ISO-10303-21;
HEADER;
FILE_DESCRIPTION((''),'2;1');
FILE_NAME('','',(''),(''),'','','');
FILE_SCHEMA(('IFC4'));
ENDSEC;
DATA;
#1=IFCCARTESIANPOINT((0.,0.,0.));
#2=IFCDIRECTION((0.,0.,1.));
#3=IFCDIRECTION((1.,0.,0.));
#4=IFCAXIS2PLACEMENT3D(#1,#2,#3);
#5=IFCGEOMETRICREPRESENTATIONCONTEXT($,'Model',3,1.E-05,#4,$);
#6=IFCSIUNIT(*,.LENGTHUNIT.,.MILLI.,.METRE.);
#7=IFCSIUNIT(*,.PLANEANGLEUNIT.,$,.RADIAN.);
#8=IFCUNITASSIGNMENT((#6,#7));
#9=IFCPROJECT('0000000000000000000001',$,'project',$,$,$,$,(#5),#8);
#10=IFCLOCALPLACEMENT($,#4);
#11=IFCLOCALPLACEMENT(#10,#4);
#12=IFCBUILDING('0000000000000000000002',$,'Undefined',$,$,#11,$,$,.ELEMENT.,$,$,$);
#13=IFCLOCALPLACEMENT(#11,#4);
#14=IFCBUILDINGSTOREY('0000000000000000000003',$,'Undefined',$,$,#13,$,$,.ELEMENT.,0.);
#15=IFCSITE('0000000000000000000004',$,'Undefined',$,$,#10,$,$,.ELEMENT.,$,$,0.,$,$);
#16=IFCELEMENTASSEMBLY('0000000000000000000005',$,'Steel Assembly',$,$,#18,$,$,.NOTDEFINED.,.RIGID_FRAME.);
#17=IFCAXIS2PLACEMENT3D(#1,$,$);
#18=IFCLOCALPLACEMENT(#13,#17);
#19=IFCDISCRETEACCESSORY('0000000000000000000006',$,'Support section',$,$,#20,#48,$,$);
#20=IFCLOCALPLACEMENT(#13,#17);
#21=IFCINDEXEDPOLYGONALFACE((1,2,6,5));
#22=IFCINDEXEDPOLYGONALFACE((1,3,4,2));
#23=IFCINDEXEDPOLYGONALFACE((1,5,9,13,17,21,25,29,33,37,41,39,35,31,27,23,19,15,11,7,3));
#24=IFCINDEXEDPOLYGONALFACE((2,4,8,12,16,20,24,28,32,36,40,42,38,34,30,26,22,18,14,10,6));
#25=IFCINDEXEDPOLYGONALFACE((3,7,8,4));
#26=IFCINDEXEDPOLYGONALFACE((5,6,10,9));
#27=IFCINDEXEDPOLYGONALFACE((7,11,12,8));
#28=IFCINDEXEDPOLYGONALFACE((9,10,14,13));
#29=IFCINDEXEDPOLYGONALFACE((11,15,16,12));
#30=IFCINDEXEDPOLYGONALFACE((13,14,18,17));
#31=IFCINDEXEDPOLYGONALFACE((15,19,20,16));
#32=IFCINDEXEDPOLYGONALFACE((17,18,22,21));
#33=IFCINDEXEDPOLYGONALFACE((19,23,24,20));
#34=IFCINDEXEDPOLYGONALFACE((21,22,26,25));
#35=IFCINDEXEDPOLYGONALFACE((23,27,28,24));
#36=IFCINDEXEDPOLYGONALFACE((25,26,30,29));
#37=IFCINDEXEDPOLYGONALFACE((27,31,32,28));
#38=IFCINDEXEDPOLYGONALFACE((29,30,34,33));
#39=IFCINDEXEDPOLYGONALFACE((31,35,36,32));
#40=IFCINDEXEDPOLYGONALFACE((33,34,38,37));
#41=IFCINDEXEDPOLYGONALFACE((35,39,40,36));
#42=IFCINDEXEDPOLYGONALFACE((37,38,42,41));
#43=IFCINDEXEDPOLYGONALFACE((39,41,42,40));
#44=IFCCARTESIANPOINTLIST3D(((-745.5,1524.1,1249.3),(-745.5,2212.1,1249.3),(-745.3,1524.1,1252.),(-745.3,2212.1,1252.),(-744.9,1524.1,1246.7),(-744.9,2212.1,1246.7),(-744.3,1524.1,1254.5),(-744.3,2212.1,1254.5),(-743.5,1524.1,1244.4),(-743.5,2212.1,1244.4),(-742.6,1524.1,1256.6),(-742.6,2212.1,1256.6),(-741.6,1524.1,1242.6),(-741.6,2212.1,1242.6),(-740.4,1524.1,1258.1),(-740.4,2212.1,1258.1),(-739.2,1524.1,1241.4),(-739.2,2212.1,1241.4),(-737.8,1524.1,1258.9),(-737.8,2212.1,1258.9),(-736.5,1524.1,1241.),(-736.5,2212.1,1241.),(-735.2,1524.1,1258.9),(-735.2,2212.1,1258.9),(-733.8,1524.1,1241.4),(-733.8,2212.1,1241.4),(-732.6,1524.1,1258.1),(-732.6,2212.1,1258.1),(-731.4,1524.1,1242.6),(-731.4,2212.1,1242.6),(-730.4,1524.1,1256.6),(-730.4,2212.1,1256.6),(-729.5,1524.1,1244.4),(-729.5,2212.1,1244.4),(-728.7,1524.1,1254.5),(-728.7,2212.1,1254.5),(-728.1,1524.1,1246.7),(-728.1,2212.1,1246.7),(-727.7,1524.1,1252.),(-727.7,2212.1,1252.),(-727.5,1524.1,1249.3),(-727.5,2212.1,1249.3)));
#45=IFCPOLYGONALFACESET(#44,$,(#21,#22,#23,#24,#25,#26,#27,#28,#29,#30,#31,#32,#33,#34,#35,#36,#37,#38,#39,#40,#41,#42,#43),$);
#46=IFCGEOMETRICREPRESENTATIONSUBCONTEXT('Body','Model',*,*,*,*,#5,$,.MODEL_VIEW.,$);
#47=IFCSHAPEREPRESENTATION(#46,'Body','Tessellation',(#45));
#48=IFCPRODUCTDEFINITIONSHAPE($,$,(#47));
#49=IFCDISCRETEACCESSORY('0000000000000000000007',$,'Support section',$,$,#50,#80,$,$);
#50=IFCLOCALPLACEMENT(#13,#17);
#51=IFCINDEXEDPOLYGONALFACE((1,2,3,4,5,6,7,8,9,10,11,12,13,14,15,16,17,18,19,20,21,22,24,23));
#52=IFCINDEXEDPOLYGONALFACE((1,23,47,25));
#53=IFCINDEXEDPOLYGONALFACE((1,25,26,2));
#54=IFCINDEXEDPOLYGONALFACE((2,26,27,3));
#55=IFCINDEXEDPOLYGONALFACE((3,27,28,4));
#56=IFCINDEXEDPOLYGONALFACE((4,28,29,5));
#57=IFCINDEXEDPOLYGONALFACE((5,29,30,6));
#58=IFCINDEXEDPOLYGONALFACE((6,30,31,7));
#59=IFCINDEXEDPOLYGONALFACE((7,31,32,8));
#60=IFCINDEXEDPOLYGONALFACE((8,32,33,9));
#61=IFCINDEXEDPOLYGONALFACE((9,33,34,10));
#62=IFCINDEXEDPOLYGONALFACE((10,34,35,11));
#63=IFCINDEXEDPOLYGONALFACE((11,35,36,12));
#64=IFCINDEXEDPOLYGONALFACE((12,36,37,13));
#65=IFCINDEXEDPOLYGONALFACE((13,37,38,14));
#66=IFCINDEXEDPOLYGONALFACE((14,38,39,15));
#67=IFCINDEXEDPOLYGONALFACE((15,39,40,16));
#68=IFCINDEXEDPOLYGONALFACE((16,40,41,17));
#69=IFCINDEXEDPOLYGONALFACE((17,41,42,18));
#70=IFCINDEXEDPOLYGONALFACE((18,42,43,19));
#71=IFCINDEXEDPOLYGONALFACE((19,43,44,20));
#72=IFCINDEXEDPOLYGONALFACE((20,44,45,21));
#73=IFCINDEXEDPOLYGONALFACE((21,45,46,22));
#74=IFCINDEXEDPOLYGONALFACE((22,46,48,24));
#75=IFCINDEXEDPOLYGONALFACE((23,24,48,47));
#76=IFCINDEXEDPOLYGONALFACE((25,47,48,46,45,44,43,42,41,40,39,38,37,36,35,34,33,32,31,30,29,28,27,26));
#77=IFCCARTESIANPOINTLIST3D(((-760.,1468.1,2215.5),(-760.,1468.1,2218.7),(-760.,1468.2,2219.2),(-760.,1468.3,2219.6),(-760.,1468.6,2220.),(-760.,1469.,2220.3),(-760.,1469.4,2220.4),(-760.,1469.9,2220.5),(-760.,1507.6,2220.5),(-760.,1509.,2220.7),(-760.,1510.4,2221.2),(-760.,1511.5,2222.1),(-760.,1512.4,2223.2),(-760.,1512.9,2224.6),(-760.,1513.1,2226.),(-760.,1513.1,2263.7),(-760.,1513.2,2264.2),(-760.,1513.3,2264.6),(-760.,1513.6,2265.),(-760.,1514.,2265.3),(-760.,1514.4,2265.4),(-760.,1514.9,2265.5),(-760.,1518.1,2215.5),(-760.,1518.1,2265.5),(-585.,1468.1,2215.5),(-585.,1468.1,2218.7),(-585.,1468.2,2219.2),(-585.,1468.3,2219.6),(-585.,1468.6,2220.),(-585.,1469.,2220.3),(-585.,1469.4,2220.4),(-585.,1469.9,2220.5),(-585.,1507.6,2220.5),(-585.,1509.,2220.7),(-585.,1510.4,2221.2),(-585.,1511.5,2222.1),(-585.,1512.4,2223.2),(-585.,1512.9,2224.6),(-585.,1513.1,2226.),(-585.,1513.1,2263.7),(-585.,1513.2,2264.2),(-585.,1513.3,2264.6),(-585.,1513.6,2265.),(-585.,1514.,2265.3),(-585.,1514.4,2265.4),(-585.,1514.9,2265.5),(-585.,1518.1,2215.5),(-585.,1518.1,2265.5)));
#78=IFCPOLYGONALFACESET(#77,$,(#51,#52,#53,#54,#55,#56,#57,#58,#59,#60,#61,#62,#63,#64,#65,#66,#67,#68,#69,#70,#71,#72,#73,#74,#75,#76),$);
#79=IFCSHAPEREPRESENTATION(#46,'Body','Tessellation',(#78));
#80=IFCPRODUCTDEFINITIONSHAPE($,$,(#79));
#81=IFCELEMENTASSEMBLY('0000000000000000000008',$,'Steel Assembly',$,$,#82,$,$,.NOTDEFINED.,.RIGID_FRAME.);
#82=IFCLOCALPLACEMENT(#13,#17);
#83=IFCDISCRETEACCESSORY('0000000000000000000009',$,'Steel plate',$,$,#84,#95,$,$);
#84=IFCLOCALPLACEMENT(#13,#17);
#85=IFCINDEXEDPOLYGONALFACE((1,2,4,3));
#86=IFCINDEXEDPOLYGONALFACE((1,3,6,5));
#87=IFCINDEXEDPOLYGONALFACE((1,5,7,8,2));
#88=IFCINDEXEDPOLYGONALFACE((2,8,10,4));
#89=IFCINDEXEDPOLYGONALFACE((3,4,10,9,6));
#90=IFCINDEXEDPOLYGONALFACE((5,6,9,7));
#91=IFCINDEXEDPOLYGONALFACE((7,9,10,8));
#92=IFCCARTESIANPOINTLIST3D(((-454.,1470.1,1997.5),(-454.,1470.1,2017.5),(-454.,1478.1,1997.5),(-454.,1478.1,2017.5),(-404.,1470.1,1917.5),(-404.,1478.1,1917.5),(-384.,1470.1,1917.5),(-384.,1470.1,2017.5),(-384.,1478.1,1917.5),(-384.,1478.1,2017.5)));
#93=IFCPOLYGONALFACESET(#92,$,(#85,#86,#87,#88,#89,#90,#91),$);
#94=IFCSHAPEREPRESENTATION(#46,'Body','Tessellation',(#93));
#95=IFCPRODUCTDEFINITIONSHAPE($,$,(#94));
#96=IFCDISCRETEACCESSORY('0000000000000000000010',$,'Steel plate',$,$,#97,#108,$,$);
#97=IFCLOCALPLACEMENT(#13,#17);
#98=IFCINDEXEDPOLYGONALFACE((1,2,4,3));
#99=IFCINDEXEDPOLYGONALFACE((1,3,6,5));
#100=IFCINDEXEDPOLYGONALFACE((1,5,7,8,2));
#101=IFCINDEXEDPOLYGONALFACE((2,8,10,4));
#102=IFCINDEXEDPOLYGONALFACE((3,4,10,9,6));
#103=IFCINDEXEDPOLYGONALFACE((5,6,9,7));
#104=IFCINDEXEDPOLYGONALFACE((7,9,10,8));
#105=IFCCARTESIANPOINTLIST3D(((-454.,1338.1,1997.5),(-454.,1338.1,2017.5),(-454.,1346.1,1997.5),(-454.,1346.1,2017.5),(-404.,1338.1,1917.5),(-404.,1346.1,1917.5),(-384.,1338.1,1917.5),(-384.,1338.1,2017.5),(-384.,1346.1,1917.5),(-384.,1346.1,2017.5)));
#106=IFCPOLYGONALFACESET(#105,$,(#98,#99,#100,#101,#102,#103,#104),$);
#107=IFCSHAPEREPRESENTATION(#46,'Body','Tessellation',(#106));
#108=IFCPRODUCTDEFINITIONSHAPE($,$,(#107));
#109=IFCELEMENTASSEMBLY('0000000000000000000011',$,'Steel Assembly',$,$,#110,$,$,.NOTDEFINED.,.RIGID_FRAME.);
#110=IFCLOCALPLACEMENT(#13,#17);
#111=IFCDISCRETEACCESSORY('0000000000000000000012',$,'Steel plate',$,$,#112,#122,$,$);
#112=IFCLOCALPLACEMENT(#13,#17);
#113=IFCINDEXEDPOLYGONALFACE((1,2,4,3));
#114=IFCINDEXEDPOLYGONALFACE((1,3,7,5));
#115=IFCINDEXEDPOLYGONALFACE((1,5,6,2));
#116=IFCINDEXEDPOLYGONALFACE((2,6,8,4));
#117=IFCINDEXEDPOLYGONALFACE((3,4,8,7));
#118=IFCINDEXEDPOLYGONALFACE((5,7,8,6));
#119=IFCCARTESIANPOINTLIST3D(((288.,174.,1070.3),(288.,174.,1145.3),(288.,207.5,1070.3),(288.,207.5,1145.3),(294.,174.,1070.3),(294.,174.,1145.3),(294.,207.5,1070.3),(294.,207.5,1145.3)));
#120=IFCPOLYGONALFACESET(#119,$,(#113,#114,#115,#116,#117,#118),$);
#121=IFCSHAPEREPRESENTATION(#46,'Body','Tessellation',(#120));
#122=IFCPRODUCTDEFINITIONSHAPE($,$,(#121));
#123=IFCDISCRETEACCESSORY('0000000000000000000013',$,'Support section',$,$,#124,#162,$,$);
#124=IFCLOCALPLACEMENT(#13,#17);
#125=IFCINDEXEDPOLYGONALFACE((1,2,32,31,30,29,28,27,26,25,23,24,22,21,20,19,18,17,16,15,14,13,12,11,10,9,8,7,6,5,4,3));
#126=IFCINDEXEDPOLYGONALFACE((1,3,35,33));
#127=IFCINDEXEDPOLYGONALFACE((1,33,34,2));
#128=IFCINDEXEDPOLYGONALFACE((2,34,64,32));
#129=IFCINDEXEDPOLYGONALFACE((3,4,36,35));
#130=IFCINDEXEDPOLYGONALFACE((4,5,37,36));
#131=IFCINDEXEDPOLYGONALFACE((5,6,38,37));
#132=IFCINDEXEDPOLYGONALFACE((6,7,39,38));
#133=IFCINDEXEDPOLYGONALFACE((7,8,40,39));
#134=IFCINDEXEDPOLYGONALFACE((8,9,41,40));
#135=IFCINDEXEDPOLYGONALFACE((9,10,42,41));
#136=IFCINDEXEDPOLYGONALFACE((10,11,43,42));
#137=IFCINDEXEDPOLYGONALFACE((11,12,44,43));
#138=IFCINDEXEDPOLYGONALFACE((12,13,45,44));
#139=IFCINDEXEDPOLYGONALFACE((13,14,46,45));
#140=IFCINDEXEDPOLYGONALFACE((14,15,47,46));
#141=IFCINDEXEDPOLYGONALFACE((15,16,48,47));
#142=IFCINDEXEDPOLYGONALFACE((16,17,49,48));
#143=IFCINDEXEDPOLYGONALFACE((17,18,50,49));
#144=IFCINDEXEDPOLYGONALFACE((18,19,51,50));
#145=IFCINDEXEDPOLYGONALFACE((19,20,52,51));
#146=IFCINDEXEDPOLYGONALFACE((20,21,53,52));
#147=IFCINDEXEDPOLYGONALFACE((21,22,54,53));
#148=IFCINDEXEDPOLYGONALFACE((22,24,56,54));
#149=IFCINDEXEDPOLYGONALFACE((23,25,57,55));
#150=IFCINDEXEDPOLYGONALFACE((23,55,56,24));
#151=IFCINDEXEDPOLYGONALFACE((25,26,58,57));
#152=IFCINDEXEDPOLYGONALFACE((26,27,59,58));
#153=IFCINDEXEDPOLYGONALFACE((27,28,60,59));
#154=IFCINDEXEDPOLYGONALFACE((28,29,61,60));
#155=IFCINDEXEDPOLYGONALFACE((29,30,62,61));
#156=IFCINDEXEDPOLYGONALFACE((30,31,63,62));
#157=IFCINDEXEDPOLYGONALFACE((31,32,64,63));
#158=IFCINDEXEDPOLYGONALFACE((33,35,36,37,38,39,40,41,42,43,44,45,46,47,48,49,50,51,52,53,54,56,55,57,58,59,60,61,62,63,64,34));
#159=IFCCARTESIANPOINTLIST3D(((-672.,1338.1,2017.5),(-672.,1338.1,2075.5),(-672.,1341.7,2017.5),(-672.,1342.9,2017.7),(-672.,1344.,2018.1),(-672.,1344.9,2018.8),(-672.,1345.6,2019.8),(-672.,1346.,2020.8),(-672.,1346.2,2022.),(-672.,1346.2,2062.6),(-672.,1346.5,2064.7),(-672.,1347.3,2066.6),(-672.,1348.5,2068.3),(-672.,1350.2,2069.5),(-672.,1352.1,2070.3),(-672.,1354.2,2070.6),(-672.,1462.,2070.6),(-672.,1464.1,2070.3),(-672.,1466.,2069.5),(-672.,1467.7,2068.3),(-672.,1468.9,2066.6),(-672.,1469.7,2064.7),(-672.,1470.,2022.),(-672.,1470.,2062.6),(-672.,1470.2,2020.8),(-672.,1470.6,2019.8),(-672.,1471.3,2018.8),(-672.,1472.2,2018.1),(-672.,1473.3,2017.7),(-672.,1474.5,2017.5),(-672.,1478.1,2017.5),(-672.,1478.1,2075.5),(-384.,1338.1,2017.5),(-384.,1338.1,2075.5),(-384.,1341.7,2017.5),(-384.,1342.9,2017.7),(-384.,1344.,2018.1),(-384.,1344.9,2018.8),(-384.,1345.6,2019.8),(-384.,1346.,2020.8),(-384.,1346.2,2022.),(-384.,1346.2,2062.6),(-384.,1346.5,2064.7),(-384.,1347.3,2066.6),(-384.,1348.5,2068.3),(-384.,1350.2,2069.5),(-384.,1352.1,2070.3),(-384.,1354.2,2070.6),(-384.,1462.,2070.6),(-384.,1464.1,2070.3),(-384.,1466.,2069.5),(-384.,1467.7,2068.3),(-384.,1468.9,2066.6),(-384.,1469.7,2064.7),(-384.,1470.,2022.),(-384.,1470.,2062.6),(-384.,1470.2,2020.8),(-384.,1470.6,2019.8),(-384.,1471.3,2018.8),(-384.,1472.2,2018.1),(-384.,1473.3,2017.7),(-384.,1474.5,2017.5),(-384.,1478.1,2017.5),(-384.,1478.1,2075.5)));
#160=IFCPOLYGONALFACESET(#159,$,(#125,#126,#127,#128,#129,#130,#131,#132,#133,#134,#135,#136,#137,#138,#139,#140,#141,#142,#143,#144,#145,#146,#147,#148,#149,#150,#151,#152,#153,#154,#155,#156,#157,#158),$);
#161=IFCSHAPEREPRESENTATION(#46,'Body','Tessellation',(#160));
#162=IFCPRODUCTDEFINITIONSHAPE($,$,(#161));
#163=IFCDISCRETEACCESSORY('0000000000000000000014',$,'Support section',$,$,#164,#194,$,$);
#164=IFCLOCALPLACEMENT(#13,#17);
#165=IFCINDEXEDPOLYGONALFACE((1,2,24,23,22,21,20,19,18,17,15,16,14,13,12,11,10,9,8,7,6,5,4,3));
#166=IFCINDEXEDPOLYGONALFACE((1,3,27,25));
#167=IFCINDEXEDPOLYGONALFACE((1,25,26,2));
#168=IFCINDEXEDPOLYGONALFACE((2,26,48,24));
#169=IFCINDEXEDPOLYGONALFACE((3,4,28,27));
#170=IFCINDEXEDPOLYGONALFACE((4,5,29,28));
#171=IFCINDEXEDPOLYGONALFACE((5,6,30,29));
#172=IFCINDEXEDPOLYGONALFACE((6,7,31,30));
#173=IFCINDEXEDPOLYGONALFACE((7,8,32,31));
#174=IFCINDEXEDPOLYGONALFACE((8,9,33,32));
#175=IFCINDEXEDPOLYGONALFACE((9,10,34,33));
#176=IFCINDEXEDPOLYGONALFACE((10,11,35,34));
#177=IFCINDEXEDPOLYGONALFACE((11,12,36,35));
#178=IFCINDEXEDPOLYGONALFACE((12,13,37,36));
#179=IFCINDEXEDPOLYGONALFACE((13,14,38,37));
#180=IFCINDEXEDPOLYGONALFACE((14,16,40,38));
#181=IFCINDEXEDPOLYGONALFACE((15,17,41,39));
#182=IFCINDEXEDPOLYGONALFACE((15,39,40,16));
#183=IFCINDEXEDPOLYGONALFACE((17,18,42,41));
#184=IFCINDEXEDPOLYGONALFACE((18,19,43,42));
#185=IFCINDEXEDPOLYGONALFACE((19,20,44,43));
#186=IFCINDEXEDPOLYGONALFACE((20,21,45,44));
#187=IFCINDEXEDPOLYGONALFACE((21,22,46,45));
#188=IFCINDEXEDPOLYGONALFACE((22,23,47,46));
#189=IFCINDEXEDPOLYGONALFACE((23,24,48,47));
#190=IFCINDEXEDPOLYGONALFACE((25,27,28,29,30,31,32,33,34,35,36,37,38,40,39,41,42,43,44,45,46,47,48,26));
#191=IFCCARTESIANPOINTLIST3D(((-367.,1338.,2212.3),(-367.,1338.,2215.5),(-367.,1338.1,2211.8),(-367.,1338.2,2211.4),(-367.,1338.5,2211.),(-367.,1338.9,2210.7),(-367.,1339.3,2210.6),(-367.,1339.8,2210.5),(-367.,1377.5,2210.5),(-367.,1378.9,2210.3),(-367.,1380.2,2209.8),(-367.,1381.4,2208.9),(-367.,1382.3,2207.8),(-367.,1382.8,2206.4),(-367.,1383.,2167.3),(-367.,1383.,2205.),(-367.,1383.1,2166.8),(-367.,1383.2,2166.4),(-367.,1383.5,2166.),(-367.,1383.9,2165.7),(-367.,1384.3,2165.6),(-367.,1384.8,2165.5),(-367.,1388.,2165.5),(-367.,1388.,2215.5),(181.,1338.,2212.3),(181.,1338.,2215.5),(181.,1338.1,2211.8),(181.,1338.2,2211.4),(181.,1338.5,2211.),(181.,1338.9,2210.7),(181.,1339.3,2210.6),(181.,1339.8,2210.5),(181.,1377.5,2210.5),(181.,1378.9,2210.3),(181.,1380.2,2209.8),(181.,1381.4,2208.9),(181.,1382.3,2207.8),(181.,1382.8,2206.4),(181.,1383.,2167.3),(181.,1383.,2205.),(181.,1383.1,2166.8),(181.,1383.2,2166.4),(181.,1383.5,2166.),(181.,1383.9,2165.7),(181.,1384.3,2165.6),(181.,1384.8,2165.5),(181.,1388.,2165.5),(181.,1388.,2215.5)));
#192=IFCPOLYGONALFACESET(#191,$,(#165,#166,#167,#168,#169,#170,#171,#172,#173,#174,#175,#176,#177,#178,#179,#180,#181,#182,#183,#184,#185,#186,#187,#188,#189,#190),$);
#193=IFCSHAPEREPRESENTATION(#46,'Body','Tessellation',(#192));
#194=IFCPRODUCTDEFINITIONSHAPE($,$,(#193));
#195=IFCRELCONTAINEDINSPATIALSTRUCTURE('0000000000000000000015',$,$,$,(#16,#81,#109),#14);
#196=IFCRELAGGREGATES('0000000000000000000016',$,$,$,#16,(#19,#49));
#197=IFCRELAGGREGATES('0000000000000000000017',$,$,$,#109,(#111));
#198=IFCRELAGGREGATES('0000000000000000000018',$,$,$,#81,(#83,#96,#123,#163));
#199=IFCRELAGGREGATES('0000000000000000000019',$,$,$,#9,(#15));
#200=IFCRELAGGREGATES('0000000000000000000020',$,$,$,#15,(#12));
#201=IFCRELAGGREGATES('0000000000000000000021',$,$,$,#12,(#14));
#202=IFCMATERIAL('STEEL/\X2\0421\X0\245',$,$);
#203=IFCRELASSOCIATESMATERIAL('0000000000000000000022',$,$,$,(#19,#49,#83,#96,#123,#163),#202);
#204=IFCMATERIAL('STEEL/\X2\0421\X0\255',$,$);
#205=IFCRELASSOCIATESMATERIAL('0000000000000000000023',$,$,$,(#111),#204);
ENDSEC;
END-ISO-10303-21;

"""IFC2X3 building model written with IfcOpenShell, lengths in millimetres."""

from ifc_helpers import new_model, si_unit, frame, origin_with_axes, origin_2d_with_axis, place, context, subcontext, project, spatial, polyline, circle, l_section, u_section, outline, extrude, material, element, aggregate, save


model = new_model("IFC2X3")

# Units and contexts
model_context = context("Model", 3, precision=1e-05, world=origin_with_axes())
body_context = subcontext(model_context, "Body", "Model", "MODEL_VIEW")
ifc_project = project(units=[si_unit("LENGTHUNIT", "METRE", prefix="MILLI"), si_unit("PLANEANGLEUNIT", "RADIAN")], contexts=[model_context])

# Site, building, storey
site_placement = place(None, origin_with_axes())
site = spatial("IfcSite", under=ifc_project, at=site_placement, Name="Undefined", CompositionType="ELEMENT", RefElevation=0.0)
building_placement = place(site_placement, origin_with_axes())
building = spatial("IfcBuilding", under=site, at=building_placement, Name="Undefined", CompositionType="ELEMENT")
storey_placement = place(building_placement, origin_with_axes())
storey = spatial("IfcBuildingStorey", under=building, at=storey_placement, Name="Undefined", CompositionType="ELEMENT", Elevation=0.0)

# Shared definitions
ifc_material_1 = material(Name="STEEL/С245")

# Element assemblies, discrete accessories
assembly_1_placement = place(storey_placement, origin_with_axes())
assembly_1 = element("IfcElementAssembly", 1, at=assembly_1_placement, inside=storey, Name="Steel Assembly", AssemblyPlace="NOTDEFINED", PredefinedType="RIGID_FRAME")
discrete_accessory_1_placement = place(assembly_1_placement, frame((-736.5, 1524.1, 1250.0), z_axis=(1.0, 0.0, 0.0), x_axis=(0.0, 1.0, 0.0)))
discrete_accessory_1 = element("IfcDiscreteAccessory", 2, at=discrete_accessory_1_placement, material=ifc_material_1, Name="Support section", context=body_context, shape_type="SweptSolid", body=[
    extrude(circle(Radius=9.0, at=origin_2d_with_axis()), frame((688.0, 0.0, 0.0), z_axis=(-1.0, 0.0, 0.0), x_axis=(0.0, -1.0, 0.0)), (0.0, 0.0, 1.0), 688.0),
])
discrete_accessory_2_placement = place(assembly_1_placement, frame((-585.0, 1493.1, 2240.5), z_axis=(0.0, -1.0, 0.0), x_axis=(-1.0, 0.0, 0.0)))
discrete_accessory_2 = element("IfcDiscreteAccessory", 3, at=discrete_accessory_2_placement, material=ifc_material_1, Name="Support section", context=body_context, shape_type="SweptSolid", body=[
    extrude(l_section(Depth=50.0, Width=50.0, Thickness=5.0, FilletRadius=5.5, EdgeRadius=1.8, at=origin_2d_with_axis()), frame((175.0, 0.0, 0.0), z_axis=(-1.0, 0.0, 0.0), x_axis=(0.0, -1.0, 0.0)), (0.0, 0.0, 1.0), 175.0),
])
aggregate(assembly_1, [discrete_accessory_1, discrete_accessory_2])
assembly_2_placement = place(storey_placement, origin_with_axes())
assembly_2 = element("IfcElementAssembly", 4, at=assembly_2_placement, inside=storey, Name="Steel Assembly", AssemblyPlace="NOTDEFINED", PredefinedType="RIGID_FRAME")
discrete_accessory_3_placement = place(assembly_2_placement, frame((-384.0, 1474.1, 2017.5), z_axis=(0.0, 1.0, 0.0), x_axis=(0.0, 0.0, -1.0)))
discrete_accessory_3 = element("IfcDiscreteAccessory", 5, at=discrete_accessory_3_placement, material=ifc_material_1, Name="Steel plate", context=body_context, shape_type="SweptSolid", body=[
    extrude(outline(polyline([(0.0, 0.0), (100.0, 0.0), (100.0, 20.0), (20.0, 70.0), (0.0, 70.0), (0.0, 0.0)])), frame((0.0, 0.0, -4.0), z_axis=(0.0, 0.0, 1.0), x_axis=(1.0, 0.0, 0.0)), (0.0, 0.0, 1.0), 8.0),
])
discrete_accessory_4_placement = place(assembly_2_placement, frame((-384.0, 1342.1, 2017.5), z_axis=(0.0, 1.0, 0.0), x_axis=(0.0, 0.0, -1.0)))
discrete_accessory_4 = element("IfcDiscreteAccessory", 6, at=discrete_accessory_4_placement, material=ifc_material_1, Name="Steel plate", context=body_context, shape_type="SweptSolid", body=[
    extrude(outline(polyline([(0.0, 0.0), (100.0, 0.0), (100.0, 20.0), (20.0, 70.0), (0.0, 70.0), (0.0, 0.0)])), frame((0.0, 0.0, -4.0), z_axis=(0.0, 0.0, 1.0), x_axis=(1.0, 0.0, 0.0)), (0.0, 0.0, 1.0), 8.0),
])

# Element assembly, discrete accessory, opening
assembly_3_placement = place(storey_placement, origin_with_axes())
assembly_3 = element("IfcElementAssembly", 7, at=assembly_3_placement, inside=storey, Name="Steel Assembly", AssemblyPlace="NOTDEFINED", PredefinedType="RIGID_FRAME")
ifc_material_2 = material(Name="STEEL/С255")
discrete_accessory_5_placement = place(assembly_3_placement, frame((291.0, 207.5, 1145.3), z_axis=(-1.0, 0.0, -0.000373), x_axis=(0.000373, 0.0, -1.0)))
discrete_accessory_5 = element("IfcDiscreteAccessory", 8, at=discrete_accessory_5_placement, material=ifc_material_2, Name="Steel plate", context=body_context, shape_type="SweptSolid", body=[
    extrude(outline(polyline([(0.0, 0.0), (75.0, 0.0), (75.0, 75.0), (0.0, 75.0), (0.0, 0.0)])), frame((0.0, 0.0, -3.0), z_axis=(0.0, 0.0, 1.0), x_axis=(1.0, 0.0, 0.0)), (0.0, 0.0, 1.0), 6.0),
])
opening_1_placement = place(assembly_3_placement, frame((291.0, 207.5, 1145.3), z_axis=(-1.0, 0.0, -0.000373), x_axis=(0.000373, 0.0, -1.0)))
element("IfcOpeningElement", 9, at=opening_1_placement, cuts=discrete_accessory_5, ObjectType="Recess", context=body_context, shape_type="SweptSolid", body=[
    extrude(outline(polyline([(0.0, 0.0), (75.0, 0.0), (75.0, 150.0), (0.0, 150.0), (0.0, 0.0)])), frame((112.5, 108.5, 6.0), z_axis=(0.0, 0.0, -1.0), x_axis=(0.0, -1.0, 0.0)), (0.0, 0.0, 1.0), 12.0),
])
aggregate(assembly_3, [discrete_accessory_5])

# Discrete accessories
discrete_accessory_6_placement = place(assembly_2_placement, frame((-384.0, 1408.1, 2046.5), z_axis=(0.0, 1.0, 0.0), x_axis=(-1.0, 0.0, 0.0)))
discrete_accessory_6 = element("IfcDiscreteAccessory", 10, at=discrete_accessory_6_placement, material=ifc_material_1, Name="Support section", context=body_context, shape_type="SweptSolid", body=[
    extrude(u_section(Depth=140.0, FlangeWidth=58.0, WebThickness=4.9, FlangeThickness=8.1, FilletRadius=8.0, EdgeRadius=4.5, at=origin_2d_with_axis()), frame((288.0, 0.0, 0.0), z_axis=(-1.0, 0.0, 0.0), x_axis=(0.0, -1.0, 0.0)), (0.0, 0.0, 1.0), 288.0),
])
discrete_accessory_7_placement = place(assembly_2_placement, frame((-367.0, 1363.0, 2190.5), z_axis=(0.0, -1.0, 0.0), x_axis=(1.0, 0.0, 0.0)))
discrete_accessory_7 = element("IfcDiscreteAccessory", 11, at=discrete_accessory_7_placement, material=ifc_material_1, Name="Support section", context=body_context, shape_type="SweptSolid", body=[
    extrude(l_section(Depth=50.0, Width=50.0, Thickness=5.0, FilletRadius=5.5, EdgeRadius=1.8, at=origin_2d_with_axis()), frame((548.0, 0.0, 0.0), z_axis=(-1.0, 0.0, 0.0), x_axis=(0.0, -1.0, 0.0)), (0.0, 0.0, 1.0), 548.0),
])
aggregate(assembly_2, [discrete_accessory_3, discrete_accessory_4, discrete_accessory_6, discrete_accessory_7])

save(model, "model.ifc")
